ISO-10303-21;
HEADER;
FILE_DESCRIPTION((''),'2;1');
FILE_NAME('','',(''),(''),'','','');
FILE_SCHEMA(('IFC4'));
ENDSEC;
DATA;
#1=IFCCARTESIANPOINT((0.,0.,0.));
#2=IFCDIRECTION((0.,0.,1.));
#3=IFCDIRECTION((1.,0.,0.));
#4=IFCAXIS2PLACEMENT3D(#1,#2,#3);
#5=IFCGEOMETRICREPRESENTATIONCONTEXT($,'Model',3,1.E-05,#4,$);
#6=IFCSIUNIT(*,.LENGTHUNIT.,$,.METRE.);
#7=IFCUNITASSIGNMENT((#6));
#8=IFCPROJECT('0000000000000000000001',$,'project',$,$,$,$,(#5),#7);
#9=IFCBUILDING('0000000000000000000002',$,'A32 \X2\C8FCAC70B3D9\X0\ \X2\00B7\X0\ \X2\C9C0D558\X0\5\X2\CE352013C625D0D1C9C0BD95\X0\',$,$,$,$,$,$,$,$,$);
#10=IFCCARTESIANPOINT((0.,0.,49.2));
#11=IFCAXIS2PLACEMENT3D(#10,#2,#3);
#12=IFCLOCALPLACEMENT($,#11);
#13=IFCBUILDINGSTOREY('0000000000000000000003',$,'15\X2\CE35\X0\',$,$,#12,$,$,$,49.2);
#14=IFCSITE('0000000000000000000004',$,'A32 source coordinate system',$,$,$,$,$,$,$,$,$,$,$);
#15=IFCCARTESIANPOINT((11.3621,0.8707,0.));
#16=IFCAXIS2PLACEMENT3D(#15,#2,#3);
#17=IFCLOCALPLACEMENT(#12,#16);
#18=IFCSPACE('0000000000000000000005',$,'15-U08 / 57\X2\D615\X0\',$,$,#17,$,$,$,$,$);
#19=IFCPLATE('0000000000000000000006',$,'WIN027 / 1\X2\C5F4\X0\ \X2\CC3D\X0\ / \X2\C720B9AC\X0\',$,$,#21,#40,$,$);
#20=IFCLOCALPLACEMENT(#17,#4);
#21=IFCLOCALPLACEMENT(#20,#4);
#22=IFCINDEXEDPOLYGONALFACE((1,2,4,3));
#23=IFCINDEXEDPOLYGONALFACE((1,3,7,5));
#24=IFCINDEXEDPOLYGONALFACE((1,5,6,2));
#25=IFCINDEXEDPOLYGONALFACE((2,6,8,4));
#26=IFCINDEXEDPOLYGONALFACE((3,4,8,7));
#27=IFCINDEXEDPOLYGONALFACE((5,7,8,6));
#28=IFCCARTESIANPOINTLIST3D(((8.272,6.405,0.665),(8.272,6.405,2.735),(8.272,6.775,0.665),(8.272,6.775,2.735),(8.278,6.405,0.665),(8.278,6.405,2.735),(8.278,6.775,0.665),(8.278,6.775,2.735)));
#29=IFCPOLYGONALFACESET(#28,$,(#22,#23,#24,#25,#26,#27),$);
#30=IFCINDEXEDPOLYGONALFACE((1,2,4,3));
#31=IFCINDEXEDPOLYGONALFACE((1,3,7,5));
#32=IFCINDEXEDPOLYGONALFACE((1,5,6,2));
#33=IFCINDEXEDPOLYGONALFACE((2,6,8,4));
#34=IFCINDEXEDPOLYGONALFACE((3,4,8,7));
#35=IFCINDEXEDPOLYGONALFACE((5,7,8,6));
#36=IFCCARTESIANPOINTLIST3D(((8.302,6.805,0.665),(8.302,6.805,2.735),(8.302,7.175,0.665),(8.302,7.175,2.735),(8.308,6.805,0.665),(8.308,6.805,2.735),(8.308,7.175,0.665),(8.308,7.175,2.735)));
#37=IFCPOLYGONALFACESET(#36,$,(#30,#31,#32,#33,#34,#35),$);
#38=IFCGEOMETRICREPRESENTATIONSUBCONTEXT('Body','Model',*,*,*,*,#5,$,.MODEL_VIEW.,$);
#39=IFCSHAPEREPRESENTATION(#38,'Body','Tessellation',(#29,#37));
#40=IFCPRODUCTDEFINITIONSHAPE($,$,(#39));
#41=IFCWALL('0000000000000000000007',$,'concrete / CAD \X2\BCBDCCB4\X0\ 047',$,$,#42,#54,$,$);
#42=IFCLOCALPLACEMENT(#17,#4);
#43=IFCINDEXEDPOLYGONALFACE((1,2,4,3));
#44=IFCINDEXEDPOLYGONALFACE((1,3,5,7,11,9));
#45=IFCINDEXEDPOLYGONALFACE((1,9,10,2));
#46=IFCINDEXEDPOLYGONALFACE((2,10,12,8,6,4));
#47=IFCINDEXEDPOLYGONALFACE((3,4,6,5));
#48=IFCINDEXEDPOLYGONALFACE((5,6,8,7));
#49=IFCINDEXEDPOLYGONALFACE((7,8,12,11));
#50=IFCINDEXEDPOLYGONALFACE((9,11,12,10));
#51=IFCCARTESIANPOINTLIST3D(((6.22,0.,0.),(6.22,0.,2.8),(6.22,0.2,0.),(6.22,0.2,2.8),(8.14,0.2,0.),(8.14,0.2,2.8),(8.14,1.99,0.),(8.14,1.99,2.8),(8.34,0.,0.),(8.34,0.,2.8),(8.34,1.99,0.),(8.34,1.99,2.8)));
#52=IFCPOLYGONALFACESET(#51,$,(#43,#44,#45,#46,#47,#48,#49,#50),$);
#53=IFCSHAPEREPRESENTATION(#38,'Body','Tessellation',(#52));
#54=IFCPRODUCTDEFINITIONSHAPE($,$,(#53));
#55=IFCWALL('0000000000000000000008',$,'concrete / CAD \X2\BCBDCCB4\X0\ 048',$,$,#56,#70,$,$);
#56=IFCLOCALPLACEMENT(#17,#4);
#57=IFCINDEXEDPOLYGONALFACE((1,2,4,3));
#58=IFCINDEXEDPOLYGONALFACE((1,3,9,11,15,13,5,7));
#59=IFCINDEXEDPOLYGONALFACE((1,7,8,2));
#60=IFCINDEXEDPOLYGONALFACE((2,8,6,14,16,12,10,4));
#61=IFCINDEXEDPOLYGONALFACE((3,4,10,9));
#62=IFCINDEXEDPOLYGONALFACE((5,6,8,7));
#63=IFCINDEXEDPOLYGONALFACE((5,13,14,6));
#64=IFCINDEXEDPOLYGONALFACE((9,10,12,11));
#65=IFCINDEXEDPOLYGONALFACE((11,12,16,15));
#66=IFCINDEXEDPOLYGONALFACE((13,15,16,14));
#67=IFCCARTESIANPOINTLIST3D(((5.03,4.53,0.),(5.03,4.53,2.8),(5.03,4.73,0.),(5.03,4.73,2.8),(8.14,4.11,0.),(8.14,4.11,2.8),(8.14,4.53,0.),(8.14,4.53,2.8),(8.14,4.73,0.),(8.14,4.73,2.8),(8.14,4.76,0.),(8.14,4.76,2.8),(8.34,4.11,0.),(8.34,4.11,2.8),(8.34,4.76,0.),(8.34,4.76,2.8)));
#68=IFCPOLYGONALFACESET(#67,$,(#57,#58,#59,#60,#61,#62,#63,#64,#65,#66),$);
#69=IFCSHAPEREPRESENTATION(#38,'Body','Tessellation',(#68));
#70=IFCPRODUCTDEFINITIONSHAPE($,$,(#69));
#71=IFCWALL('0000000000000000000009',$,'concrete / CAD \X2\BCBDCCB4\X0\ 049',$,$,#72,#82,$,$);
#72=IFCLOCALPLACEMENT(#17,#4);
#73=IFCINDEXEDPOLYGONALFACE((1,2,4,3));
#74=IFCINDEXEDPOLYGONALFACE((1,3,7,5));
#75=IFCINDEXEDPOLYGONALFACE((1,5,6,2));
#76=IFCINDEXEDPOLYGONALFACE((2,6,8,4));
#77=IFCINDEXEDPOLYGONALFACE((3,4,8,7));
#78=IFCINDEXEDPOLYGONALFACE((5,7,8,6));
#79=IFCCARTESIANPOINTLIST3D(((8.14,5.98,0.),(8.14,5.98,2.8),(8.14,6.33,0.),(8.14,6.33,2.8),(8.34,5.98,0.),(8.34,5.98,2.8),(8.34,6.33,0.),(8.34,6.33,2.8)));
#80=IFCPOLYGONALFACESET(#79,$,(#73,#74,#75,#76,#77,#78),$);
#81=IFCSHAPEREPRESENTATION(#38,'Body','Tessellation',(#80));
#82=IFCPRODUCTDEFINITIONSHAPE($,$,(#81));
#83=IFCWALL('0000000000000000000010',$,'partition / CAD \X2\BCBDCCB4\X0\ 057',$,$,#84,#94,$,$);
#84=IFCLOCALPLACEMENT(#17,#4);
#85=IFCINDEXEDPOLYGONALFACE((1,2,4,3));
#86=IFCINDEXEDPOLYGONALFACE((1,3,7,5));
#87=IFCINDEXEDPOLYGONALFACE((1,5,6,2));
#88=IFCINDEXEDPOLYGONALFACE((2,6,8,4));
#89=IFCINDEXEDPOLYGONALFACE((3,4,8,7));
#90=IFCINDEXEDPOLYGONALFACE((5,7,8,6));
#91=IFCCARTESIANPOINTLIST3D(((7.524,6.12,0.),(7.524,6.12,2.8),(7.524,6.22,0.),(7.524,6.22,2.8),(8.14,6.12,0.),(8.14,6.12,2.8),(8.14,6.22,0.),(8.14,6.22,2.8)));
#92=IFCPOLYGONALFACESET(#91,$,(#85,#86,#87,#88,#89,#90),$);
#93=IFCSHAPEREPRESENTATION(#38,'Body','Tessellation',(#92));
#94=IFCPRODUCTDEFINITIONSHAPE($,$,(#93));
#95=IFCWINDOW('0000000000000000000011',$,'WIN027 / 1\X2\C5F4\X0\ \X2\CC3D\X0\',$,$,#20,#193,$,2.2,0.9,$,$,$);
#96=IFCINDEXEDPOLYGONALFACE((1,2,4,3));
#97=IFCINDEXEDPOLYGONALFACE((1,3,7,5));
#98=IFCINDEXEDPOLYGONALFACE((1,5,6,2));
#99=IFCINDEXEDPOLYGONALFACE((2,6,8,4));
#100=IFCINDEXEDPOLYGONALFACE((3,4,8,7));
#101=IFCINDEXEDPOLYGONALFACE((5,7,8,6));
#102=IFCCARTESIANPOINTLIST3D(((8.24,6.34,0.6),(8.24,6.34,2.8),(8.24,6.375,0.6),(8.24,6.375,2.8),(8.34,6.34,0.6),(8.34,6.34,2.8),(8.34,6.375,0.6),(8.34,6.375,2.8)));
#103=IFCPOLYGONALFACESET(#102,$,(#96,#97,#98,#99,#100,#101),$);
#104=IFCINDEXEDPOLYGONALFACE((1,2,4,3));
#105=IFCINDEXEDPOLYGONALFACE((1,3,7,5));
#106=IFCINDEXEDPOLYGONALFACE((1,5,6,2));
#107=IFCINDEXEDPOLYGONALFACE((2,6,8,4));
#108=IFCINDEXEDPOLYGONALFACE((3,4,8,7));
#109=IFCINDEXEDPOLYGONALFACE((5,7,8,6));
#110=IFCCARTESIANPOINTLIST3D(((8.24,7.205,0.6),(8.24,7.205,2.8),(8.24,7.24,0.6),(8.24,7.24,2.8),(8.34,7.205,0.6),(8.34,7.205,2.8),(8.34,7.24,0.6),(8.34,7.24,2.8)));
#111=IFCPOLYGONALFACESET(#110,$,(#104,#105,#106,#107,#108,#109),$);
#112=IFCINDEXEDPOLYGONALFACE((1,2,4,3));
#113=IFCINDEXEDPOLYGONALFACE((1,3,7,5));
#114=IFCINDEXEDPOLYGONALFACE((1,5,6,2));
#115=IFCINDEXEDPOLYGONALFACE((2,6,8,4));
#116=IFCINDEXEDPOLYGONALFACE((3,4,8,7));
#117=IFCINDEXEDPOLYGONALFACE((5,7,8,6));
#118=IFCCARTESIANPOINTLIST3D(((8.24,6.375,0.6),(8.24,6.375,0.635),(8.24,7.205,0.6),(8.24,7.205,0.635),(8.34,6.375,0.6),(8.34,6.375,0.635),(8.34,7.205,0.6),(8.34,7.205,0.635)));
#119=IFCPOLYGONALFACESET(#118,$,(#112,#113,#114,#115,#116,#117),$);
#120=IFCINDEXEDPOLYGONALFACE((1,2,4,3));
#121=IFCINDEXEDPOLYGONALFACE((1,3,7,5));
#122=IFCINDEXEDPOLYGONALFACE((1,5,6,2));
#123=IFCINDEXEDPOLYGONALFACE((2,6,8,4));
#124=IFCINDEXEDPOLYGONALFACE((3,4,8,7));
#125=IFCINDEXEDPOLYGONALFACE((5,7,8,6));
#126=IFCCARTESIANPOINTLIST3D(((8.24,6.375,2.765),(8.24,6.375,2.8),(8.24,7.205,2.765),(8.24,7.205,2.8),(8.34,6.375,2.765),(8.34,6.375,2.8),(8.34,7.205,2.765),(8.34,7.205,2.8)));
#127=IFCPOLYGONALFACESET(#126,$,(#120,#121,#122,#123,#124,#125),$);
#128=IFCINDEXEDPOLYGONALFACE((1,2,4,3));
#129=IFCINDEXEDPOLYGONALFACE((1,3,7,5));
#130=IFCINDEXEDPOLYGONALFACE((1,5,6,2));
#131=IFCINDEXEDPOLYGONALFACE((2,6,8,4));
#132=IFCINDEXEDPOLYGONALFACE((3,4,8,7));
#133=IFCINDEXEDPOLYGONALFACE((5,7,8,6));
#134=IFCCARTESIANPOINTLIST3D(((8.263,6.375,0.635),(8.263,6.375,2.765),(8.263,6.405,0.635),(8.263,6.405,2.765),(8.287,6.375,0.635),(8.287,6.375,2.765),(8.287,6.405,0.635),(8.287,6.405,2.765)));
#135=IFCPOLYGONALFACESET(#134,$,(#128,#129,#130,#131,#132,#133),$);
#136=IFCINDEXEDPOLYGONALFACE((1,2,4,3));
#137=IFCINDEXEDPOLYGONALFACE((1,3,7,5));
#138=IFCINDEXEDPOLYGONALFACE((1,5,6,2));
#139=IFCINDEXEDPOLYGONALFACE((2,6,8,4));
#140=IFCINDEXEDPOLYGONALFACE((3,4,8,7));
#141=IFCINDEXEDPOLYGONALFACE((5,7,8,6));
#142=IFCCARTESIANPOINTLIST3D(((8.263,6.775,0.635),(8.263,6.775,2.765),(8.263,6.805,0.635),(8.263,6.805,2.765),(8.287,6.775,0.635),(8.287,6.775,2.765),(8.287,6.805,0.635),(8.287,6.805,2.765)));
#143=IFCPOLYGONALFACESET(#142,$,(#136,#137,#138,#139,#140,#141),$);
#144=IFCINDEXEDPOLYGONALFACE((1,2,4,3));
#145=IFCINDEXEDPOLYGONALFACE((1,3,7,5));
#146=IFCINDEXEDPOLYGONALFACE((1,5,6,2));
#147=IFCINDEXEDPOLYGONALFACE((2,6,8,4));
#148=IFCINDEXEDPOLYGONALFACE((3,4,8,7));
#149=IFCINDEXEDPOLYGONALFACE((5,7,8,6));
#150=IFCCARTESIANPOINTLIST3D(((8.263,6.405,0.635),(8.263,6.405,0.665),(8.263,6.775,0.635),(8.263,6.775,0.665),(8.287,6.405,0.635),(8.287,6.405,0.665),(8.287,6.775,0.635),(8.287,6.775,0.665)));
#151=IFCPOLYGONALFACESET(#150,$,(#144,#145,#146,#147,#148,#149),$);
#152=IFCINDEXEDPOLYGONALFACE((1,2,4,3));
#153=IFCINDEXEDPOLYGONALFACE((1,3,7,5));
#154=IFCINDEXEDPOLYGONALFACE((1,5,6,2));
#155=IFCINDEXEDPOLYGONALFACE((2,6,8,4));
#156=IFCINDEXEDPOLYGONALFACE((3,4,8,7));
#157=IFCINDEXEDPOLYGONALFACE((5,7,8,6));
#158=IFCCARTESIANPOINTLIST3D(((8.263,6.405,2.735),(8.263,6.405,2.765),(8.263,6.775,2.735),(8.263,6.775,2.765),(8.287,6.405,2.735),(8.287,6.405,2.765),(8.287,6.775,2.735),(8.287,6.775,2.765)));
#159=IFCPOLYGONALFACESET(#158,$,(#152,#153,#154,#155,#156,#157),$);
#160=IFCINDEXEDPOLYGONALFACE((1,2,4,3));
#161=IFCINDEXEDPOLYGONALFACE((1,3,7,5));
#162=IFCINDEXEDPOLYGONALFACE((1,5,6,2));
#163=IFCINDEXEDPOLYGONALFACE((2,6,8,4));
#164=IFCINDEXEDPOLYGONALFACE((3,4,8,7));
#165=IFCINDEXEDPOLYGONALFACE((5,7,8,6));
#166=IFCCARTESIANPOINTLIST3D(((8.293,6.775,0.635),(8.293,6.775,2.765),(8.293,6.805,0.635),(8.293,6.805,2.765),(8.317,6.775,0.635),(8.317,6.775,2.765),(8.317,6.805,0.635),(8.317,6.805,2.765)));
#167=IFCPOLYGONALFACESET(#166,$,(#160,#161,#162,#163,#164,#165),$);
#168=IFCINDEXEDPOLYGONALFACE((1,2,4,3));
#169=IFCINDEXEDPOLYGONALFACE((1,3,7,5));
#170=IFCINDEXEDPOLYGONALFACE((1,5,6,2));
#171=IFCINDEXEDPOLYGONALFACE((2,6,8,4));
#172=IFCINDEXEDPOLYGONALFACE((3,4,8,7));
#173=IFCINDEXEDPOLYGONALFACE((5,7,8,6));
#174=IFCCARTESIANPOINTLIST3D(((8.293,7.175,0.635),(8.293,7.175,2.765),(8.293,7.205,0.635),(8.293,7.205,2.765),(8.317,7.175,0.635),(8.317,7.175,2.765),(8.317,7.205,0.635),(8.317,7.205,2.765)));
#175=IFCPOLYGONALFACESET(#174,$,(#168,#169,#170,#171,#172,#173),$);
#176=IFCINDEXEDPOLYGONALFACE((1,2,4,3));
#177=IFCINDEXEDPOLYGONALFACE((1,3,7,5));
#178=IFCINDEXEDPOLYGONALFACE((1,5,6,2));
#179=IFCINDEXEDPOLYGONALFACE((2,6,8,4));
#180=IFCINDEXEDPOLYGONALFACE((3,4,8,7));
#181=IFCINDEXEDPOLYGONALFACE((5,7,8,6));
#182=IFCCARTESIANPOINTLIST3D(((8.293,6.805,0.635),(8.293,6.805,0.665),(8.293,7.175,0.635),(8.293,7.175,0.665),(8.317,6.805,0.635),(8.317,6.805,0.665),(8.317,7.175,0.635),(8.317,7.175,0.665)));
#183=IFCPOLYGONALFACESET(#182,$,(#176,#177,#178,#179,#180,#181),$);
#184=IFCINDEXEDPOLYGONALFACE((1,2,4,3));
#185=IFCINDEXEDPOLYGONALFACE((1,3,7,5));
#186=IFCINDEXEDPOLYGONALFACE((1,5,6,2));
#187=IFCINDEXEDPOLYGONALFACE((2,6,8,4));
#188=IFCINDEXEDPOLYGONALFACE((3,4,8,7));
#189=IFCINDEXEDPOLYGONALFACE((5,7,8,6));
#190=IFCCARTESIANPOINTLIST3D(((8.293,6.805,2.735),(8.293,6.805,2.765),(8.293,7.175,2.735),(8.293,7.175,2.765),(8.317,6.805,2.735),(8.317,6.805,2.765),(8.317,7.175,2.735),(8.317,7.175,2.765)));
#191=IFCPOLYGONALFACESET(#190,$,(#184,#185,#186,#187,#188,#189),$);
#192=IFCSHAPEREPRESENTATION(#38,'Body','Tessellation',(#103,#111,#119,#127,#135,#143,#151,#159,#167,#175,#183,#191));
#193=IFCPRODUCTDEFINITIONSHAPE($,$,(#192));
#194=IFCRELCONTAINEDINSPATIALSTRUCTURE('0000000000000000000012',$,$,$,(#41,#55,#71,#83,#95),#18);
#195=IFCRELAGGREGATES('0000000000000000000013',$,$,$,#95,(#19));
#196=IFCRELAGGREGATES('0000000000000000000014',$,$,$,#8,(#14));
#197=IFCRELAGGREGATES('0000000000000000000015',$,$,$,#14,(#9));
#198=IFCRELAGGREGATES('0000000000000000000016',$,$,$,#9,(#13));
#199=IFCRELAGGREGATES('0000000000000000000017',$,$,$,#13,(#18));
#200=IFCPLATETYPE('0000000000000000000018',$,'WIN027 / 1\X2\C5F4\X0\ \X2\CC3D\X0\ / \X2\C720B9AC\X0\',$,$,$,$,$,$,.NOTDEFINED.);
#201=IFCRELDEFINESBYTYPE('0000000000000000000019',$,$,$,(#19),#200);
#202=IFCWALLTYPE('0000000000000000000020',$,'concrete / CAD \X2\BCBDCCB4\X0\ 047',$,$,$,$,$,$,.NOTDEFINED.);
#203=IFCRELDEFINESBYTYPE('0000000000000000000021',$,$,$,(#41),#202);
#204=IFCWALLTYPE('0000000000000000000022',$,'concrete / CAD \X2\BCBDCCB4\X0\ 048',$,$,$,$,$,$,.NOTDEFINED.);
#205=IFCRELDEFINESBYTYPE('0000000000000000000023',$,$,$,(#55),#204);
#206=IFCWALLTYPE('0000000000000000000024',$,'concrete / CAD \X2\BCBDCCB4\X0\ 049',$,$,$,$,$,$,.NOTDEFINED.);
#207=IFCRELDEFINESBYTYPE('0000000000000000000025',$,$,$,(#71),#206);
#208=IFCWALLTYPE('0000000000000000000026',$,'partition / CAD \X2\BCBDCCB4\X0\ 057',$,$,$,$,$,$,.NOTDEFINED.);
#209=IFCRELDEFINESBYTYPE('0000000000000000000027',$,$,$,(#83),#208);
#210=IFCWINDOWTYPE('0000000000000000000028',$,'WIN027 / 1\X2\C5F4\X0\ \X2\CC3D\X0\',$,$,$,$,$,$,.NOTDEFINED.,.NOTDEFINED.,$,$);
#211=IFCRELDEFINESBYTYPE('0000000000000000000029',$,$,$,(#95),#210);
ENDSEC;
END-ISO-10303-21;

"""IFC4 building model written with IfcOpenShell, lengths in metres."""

from ifc_helpers import new_model, si_unit, frame, origin, origin_with_axes, place, context, subcontext, project, spatial, polyline, outline, extrude, source, transform, mapped, type_object, type_shapes, element, aggregate, save


model = new_model("IFC4")

# Units and contexts
model_context = context("Model", 3, precision=1e-05, world=origin_with_axes())
body_context = subcontext(model_context, "Body", "Model", "MODEL_VIEW")
ifc_project = project(units=[si_unit("LENGTHUNIT", "METRE")], contexts=[model_context])

# Plate
storey_placement = place(None, frame((0.0, 0.0, 49.2), z_axis=(0.0, 0.0, 1.0), x_axis=(1.0, 0.0, 0.0)))
space_placement = place(storey_placement, frame((11.3621, 0.8707, 0.0), z_axis=(0.0, 0.0, 1.0), x_axis=(1.0, 0.0, 0.0)))
plate_type_1 = type_object("IfcPlateType", Name="WIN027 / 1열 창 / 유리", PredefinedType="NOTDEFINED")
shared_shape_1 = source(origin(), body_context, "Body", "SweptSolid", [
    extrude(outline(polyline([(8.272, 6.405), (8.272, 6.775), (8.278, 6.775), (8.278, 6.405), (8.272, 6.405)])), frame((0.0, 0.0, 0.665)), (0.0, 0.0, 1.0), 2.07),
    extrude(outline(polyline([(8.302, 6.805), (8.302, 7.175), (8.308, 7.175), (8.308, 6.805), (8.302, 6.805)])), frame((0.0, 0.0, 0.665)), (0.0, 0.0, 1.0), 2.07),
])
type_shapes(plate_type_1, [shared_shape_1])
window_1_placement = place(space_placement, origin_with_axes())
plate_1_placement = place(window_1_placement, origin_with_axes())
plate_1 = element("IfcPlate", 1, at=plate_1_placement, type_object=plate_type_1, Name="WIN027 / 1열 창 / 유리", context=body_context, shape_type="MappedRepresentation", body=[
    mapped(shared_shape_1, transform((0.0, 0.0, 0.0), scale=1.0)),
])

# Site, building, storey, space
site = spatial("IfcSite", under=ifc_project, Name="A32 source coordinate system")
building = spatial("IfcBuilding", under=site, Name="A32 주거동 · 지하5층–옥탑지붕")
storey = spatial("IfcBuildingStorey", under=building, at=storey_placement, Name="15층", Elevation=49.2)
space = spatial("IfcSpace", under=storey, at=space_placement, Name="15-U08 / 57형")

# Walls
wall_type_1 = type_object("IfcWallType", Name="concrete / CAD 벽체 047", PredefinedType="NOTDEFINED")
shared_shape_2 = source(origin(), body_context, "Body", "SweptSolid", [
    extrude(outline(polyline([(8.14, 1.99), (8.34, 1.99), (8.34, 0.0), (6.22, 0.0), (6.22, 0.2), (8.14, 0.2), (8.14, 1.99)])), origin(), (0.0, 0.0, 1.0), 2.8),
])
type_shapes(wall_type_1, [shared_shape_2])
wall_1_placement = place(space_placement, origin_with_axes())
element("IfcWall", 2, at=wall_1_placement, inside=space, type_object=wall_type_1, Name="concrete / CAD 벽체 047", context=body_context, shape_type="MappedRepresentation", body=[
    mapped(shared_shape_2, transform((0.0, 0.0, 0.0), scale=1.0)),
])
wall_type_2 = type_object("IfcWallType", Name="concrete / CAD 벽체 048", PredefinedType="NOTDEFINED")
shared_shape_3 = source(origin(), body_context, "Body", "SweptSolid", [
    extrude(outline(polyline([(8.14, 4.53), (5.03, 4.53), (5.03, 4.73), (8.14, 4.73), (8.14, 4.76), (8.34, 4.76), (8.34, 4.11), (8.14, 4.11), (8.14, 4.53)])), origin(), (0.0, 0.0, 1.0), 2.8),
])
type_shapes(wall_type_2, [shared_shape_3])
wall_2_placement = place(space_placement, origin_with_axes())
element("IfcWall", 3, at=wall_2_placement, inside=space, type_object=wall_type_2, Name="concrete / CAD 벽체 048", context=body_context, shape_type="MappedRepresentation", body=[
    mapped(shared_shape_3, transform((0.0, 0.0, 0.0), scale=1.0)),
])
wall_type_3 = type_object("IfcWallType", Name="concrete / CAD 벽체 049", PredefinedType="NOTDEFINED")
shared_shape_4 = source(origin(), body_context, "Body", "SweptSolid", [
    extrude(outline(polyline([(8.34, 6.33), (8.34, 5.98), (8.14, 5.98), (8.14, 6.33), (8.34, 6.33)])), origin(), (0.0, 0.0, 1.0), 2.8),
])
type_shapes(wall_type_3, [shared_shape_4])
wall_3_placement = place(space_placement, origin_with_axes())
element("IfcWall", 4, at=wall_3_placement, inside=space, type_object=wall_type_3, Name="concrete / CAD 벽체 049", context=body_context, shape_type="MappedRepresentation", body=[
    mapped(shared_shape_4, transform((0.0, 0.0, 0.0), scale=1.0)),
])
wall_type_4 = type_object("IfcWallType", Name="partition / CAD 벽체 057", PredefinedType="NOTDEFINED")
shared_shape_5 = source(origin(), body_context, "Body", "SweptSolid", [
    extrude(outline(polyline([(7.524, 6.22), (8.14, 6.22), (8.14, 6.12), (7.524, 6.12), (7.524, 6.22)])), origin(), (0.0, 0.0, 1.0), 2.8),
])
type_shapes(wall_type_4, [shared_shape_5])
wall_4_placement = place(space_placement, origin_with_axes())
element("IfcWall", 5, at=wall_4_placement, inside=space, type_object=wall_type_4, Name="partition / CAD 벽체 057", context=body_context, shape_type="MappedRepresentation", body=[
    mapped(shared_shape_5, transform((0.0, 0.0, 0.0), scale=1.0)),
])

# Window
window_type_1 = type_object("IfcWindowType", Name="WIN027 / 1열 창", PartitioningType="NOTDEFINED", PredefinedType="NOTDEFINED")
shared_shape_6 = source(origin(), body_context, "Body", "SweptSolid", [
    extrude(outline(polyline([(8.24, 6.34), (8.24, 6.375), (8.34, 6.375), (8.34, 6.34), (8.24, 6.34)])), frame((0.0, 0.0, 0.6)), (0.0, 0.0, 1.0), 2.2),
    extrude(outline(polyline([(8.24, 7.205), (8.24, 7.24), (8.34, 7.24), (8.34, 7.205), (8.24, 7.205)])), frame((0.0, 0.0, 0.6)), (0.0, 0.0, 1.0), 2.2),
    extrude(outline(polyline([(8.24, 6.375), (8.24, 7.205), (8.34, 7.205), (8.34, 6.375), (8.24, 6.375)])), frame((0.0, 0.0, 0.6)), (0.0, 0.0, 1.0), 0.035),
    extrude(outline(polyline([(8.24, 6.375), (8.24, 7.205), (8.34, 7.205), (8.34, 6.375), (8.24, 6.375)])), frame((0.0, 0.0, 2.765)), (0.0, 0.0, 1.0), 0.035),
    extrude(outline(polyline([(8.263, 6.375), (8.263, 6.405), (8.287, 6.405), (8.287, 6.375), (8.263, 6.375)])), frame((0.0, 0.0, 0.635)), (0.0, 0.0, 1.0), 2.13),
    extrude(outline(polyline([(8.263, 6.775), (8.263, 6.805), (8.287, 6.805), (8.287, 6.775), (8.263, 6.775)])), frame((0.0, 0.0, 0.635)), (0.0, 0.0, 1.0), 2.13),
    extrude(outline(polyline([(8.263, 6.405), (8.263, 6.775), (8.287, 6.775), (8.287, 6.405), (8.263, 6.405)])), frame((0.0, 0.0, 0.635)), (0.0, 0.0, 1.0), 0.03),
    extrude(outline(polyline([(8.263, 6.405), (8.263, 6.775), (8.287, 6.775), (8.287, 6.405), (8.263, 6.405)])), frame((0.0, 0.0, 2.735)), (0.0, 0.0, 1.0), 0.03),
    extrude(outline(polyline([(8.293, 6.775), (8.293, 6.805), (8.317, 6.805), (8.317, 6.775), (8.293, 6.775)])), frame((0.0, 0.0, 0.635)), (0.0, 0.0, 1.0), 2.13),
    extrude(outline(polyline([(8.293, 7.175), (8.293, 7.205), (8.317, 7.205), (8.317, 7.175), (8.293, 7.175)])), frame((0.0, 0.0, 0.635)), (0.0, 0.0, 1.0), 2.13),
    extrude(outline(polyline([(8.293, 6.805), (8.293, 7.175), (8.317, 7.175), (8.317, 6.805), (8.293, 6.805)])), frame((0.0, 0.0, 0.635)), (0.0, 0.0, 1.0), 0.03),
    extrude(outline(polyline([(8.293, 6.805), (8.293, 7.175), (8.317, 7.175), (8.317, 6.805), (8.293, 6.805)])), frame((0.0, 0.0, 2.735)), (0.0, 0.0, 1.0), 0.03),
])
type_shapes(window_type_1, [shared_shape_6])
window_1 = element("IfcWindow", 6, at=window_1_placement, inside=space, type_object=window_type_1, Name="WIN027 / 1열 창", OverallHeight=2.2, OverallWidth=0.9, context=body_context, shape_type="MappedRepresentation", body=[
    mapped(shared_shape_6, transform((0.0, 0.0, 0.0), scale=1.0)),
])
aggregate(window_1, [plate_1])

save(model, "model.ifc")
